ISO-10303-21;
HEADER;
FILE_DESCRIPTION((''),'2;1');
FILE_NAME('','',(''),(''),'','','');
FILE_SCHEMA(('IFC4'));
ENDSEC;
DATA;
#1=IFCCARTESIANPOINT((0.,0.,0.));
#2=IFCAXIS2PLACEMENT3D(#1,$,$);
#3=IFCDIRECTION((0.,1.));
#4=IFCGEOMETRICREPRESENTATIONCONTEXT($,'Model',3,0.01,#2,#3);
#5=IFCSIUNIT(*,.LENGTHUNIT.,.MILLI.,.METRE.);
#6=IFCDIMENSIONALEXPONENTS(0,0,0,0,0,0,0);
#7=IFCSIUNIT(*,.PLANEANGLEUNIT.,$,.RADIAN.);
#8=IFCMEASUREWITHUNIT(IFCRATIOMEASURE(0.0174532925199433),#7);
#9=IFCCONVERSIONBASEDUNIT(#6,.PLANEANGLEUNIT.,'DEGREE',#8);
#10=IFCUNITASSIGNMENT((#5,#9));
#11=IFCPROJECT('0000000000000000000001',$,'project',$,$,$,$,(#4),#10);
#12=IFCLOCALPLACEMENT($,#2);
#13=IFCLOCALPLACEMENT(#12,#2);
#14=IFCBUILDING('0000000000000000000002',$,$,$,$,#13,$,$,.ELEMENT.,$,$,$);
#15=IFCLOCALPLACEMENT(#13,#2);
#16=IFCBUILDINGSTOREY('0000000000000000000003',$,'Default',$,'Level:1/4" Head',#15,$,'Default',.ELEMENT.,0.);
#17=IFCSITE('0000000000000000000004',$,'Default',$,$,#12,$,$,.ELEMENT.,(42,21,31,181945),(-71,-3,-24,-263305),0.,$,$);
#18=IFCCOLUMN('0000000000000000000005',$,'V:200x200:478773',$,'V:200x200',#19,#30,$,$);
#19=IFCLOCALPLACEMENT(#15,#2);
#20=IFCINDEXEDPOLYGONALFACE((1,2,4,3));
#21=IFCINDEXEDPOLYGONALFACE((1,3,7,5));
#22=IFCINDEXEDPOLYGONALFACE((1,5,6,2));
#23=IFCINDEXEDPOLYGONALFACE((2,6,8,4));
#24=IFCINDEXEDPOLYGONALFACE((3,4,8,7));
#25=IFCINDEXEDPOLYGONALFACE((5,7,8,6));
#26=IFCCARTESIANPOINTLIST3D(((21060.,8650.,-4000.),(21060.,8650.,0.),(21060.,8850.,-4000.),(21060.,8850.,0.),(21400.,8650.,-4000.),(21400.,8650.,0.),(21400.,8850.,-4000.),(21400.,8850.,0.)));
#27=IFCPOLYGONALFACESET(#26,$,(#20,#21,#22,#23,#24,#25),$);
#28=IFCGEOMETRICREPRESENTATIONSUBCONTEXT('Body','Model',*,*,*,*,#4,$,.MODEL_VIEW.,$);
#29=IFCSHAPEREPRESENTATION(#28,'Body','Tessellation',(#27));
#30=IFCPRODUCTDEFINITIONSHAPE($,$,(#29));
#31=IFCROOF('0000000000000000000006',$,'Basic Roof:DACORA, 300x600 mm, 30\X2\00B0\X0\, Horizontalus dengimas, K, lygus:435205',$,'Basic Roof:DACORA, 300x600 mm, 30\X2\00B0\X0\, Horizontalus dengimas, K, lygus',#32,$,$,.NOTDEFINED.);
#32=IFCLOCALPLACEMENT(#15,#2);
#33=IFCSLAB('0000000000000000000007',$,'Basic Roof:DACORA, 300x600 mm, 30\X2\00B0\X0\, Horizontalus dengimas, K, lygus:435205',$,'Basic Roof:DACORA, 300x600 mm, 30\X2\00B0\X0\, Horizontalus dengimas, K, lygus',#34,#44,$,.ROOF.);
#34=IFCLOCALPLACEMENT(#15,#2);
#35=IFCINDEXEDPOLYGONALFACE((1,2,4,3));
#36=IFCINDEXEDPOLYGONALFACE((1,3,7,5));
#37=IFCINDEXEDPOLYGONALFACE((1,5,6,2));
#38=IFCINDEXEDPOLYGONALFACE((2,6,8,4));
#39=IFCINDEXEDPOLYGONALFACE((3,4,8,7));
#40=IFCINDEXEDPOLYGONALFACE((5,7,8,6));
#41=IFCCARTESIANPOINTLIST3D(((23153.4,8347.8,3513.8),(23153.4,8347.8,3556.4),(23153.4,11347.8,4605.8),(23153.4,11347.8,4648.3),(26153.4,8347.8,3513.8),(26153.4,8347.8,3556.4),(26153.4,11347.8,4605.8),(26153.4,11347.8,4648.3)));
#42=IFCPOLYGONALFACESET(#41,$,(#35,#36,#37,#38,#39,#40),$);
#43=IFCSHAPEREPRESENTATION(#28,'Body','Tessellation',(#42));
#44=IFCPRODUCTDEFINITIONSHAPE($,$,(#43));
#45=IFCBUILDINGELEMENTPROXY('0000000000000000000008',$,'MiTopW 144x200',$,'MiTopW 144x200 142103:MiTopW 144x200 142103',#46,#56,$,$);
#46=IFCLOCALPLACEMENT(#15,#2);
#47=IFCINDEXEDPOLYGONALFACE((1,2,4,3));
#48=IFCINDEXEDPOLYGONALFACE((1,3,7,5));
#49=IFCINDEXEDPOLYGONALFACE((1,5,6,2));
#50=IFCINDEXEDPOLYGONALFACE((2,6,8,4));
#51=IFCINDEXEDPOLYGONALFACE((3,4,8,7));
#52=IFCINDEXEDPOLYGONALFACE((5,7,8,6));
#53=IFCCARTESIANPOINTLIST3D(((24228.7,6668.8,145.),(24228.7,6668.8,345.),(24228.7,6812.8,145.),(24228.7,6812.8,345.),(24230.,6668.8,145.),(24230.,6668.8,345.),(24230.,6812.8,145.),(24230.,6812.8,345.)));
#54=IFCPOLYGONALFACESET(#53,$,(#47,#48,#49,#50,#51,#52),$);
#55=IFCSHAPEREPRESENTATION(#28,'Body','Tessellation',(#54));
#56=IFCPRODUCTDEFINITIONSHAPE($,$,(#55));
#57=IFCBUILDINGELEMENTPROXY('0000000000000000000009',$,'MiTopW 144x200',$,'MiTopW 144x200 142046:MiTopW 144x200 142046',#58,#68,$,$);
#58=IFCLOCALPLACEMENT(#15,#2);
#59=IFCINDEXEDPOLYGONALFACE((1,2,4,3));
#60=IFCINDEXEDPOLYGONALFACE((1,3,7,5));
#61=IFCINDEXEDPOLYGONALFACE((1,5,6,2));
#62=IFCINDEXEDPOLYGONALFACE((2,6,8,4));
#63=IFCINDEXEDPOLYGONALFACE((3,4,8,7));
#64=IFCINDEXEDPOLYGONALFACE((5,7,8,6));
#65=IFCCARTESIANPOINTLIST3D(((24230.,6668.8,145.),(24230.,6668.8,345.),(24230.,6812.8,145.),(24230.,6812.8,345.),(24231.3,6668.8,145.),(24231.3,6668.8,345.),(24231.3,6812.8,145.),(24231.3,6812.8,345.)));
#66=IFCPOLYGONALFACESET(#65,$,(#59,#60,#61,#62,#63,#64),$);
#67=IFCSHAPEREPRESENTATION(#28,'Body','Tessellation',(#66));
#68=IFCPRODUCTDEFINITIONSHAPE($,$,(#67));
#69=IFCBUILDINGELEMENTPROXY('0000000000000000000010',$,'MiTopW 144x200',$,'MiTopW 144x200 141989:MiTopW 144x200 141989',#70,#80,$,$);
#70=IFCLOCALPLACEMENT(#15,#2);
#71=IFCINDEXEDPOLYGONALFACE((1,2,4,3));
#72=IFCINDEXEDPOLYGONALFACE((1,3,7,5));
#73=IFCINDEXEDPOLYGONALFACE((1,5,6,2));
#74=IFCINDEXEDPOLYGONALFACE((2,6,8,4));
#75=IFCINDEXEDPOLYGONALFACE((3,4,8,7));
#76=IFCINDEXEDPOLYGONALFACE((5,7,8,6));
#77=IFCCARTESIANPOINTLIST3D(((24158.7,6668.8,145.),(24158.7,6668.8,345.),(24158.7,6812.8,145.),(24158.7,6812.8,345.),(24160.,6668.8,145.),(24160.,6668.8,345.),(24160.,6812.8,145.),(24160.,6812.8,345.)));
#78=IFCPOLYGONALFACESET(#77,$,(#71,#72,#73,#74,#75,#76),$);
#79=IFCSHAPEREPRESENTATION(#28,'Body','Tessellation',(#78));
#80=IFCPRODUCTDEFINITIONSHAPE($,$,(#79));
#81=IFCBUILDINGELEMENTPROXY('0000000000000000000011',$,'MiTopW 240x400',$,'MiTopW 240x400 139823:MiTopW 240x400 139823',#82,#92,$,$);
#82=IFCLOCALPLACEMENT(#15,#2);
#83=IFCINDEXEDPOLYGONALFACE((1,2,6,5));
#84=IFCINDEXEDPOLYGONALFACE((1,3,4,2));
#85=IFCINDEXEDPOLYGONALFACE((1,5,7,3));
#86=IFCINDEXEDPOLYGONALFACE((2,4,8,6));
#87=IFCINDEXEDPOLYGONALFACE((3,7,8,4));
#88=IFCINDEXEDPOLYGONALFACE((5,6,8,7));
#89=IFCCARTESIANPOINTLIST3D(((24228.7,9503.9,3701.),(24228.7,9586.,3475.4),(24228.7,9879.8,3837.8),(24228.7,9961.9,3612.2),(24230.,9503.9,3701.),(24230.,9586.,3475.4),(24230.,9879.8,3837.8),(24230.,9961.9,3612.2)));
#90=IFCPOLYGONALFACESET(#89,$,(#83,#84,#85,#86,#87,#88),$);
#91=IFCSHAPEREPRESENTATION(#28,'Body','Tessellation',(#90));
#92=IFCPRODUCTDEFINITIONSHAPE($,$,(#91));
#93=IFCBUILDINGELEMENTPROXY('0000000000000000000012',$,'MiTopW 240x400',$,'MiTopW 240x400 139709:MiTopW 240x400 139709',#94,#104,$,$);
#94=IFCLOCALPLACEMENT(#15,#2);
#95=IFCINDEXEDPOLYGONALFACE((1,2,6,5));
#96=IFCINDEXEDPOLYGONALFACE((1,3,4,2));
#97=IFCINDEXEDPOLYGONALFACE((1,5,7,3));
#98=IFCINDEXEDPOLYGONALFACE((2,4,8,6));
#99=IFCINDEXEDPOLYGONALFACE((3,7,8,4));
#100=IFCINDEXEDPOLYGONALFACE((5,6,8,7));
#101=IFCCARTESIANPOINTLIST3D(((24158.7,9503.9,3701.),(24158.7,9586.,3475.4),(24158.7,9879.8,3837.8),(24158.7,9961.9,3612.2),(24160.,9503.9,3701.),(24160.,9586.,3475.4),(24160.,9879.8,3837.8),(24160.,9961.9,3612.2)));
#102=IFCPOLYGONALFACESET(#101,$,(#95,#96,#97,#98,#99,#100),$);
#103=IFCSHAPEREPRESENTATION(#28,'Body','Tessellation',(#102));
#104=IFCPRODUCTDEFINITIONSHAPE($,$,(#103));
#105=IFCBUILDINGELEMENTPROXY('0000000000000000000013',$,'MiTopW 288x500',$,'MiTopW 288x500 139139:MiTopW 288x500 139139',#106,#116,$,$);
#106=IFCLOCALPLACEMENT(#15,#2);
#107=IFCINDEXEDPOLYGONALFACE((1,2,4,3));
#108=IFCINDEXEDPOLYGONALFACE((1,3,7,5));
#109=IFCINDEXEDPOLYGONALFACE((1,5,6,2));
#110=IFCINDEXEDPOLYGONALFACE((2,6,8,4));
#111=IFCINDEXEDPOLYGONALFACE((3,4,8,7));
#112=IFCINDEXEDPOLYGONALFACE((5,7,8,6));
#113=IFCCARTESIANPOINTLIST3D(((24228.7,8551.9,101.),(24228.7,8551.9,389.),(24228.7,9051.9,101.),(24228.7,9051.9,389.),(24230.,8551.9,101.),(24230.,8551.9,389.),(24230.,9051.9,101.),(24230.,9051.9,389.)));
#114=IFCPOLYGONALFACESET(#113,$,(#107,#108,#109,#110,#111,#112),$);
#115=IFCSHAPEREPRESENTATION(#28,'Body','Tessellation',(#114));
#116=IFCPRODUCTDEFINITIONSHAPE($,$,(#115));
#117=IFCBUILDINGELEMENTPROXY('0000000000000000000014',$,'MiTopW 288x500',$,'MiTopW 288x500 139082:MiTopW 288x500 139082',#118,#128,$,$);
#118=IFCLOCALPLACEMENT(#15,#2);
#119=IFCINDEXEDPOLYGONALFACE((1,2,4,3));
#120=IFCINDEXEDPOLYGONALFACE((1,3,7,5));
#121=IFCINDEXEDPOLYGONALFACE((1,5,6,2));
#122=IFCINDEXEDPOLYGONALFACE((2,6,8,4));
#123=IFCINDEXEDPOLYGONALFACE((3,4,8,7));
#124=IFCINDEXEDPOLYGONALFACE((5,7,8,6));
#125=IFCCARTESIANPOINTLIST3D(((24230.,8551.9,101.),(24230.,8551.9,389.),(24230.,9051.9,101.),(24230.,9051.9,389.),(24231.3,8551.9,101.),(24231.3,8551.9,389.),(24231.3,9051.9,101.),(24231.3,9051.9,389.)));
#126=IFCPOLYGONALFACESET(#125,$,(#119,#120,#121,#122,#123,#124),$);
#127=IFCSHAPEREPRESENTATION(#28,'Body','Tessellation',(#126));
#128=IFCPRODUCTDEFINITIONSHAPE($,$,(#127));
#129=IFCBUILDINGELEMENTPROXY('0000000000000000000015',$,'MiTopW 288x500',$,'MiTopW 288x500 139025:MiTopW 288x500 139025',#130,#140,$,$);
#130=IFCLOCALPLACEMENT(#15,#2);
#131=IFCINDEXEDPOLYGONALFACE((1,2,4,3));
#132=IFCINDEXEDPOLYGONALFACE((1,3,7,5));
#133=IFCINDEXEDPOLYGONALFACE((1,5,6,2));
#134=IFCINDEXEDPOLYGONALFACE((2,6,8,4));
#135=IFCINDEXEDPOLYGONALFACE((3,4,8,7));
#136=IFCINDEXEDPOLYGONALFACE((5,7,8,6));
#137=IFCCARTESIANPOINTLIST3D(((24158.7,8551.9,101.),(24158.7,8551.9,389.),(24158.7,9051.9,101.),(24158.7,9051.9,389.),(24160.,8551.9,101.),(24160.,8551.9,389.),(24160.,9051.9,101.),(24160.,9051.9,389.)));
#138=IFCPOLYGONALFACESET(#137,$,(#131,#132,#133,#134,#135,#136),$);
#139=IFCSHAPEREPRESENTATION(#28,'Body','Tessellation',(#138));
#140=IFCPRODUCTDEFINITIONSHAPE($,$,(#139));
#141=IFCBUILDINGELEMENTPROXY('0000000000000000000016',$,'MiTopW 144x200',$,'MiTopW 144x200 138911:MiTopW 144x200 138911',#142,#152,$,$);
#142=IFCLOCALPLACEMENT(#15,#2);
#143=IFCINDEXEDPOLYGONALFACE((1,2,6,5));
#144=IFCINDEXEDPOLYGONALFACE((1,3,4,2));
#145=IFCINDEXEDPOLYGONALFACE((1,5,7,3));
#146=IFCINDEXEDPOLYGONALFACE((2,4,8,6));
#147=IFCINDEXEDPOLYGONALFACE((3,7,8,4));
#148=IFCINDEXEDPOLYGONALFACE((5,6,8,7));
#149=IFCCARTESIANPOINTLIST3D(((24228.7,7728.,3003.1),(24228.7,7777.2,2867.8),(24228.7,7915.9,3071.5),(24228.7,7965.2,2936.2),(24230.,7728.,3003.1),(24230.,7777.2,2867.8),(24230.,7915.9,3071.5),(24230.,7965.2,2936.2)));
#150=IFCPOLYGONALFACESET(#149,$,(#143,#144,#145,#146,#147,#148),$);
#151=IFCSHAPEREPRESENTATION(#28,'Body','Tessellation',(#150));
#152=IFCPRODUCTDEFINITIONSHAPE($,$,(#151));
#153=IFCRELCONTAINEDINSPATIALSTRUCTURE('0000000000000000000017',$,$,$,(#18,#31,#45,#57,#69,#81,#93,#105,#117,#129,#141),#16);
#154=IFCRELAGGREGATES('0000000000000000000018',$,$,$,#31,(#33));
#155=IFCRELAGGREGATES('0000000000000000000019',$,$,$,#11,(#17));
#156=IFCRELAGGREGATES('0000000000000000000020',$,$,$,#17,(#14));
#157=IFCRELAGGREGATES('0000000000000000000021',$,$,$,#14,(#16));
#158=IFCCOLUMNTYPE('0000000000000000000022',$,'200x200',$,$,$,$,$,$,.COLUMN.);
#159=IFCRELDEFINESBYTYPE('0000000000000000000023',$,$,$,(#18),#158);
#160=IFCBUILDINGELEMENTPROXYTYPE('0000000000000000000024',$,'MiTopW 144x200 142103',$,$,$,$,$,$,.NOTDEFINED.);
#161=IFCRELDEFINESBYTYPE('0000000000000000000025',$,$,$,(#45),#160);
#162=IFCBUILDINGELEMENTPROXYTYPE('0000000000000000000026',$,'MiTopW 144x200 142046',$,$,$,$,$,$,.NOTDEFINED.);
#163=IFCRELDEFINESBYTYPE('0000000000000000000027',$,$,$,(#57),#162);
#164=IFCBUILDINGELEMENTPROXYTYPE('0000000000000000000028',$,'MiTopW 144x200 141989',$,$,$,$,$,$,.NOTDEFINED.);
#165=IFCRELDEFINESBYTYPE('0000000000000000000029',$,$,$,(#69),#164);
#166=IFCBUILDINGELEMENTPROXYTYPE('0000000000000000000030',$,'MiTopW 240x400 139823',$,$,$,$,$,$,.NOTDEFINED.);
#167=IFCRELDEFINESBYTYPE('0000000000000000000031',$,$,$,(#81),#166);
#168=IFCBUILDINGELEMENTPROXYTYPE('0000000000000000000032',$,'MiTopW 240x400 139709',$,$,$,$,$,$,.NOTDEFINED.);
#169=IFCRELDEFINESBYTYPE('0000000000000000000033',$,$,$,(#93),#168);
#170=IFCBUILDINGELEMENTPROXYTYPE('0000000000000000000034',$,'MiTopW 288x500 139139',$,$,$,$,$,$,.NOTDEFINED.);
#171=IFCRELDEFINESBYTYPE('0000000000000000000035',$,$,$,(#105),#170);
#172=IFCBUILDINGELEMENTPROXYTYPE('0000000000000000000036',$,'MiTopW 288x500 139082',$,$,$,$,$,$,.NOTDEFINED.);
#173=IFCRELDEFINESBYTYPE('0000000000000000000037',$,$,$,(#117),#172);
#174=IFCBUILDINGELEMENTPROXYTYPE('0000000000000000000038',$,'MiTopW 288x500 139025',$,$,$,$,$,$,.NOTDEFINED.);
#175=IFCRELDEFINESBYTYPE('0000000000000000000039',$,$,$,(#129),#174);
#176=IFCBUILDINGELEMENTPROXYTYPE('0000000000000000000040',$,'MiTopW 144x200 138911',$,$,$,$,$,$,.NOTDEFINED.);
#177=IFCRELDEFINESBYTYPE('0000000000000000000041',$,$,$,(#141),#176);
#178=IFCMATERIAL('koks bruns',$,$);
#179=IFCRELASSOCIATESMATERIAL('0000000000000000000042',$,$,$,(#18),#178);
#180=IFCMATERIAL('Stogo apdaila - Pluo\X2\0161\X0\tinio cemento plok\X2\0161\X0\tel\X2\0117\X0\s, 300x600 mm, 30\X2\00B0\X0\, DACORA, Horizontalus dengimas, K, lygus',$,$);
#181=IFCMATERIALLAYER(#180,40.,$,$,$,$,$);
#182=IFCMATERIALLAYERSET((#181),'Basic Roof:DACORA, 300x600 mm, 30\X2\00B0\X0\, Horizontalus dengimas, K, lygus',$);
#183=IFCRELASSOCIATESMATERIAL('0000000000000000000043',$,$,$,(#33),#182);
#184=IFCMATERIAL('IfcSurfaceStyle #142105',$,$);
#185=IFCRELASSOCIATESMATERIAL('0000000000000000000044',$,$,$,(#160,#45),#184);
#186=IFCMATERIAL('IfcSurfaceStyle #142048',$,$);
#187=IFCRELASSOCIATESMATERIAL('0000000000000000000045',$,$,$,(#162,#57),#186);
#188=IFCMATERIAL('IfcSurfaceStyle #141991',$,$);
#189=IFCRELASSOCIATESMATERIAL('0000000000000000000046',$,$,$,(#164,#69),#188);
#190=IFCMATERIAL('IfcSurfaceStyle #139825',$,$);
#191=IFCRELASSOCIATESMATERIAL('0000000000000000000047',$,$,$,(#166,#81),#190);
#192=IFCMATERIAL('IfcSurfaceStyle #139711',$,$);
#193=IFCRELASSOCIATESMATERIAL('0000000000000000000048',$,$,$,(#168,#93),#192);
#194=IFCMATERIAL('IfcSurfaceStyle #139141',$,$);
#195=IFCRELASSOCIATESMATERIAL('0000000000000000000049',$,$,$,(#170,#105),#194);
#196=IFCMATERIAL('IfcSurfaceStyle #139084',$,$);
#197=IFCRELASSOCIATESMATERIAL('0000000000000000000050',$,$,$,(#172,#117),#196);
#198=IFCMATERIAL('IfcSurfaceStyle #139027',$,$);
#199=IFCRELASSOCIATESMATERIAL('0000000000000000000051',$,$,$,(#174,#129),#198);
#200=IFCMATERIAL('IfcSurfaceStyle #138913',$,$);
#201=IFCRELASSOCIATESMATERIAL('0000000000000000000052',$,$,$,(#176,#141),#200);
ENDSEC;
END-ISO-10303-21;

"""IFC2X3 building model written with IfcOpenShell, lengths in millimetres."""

from ifc_helpers import new_model, entity, si_unit, converted_unit, direction, frame, frame_2d, origin, origin_2d_with_axis, place, context, subcontext, project, spatial, polyline, rectangle, outline, extrude, source, transform, mapped, material, layer, layer_set, type_object, type_shapes, element, aggregate, save


model = new_model("IFC2X3")

# Units and contexts
model_context = context("Model", 3, precision=0.01, world=origin(), true_north=direction((0.0, 1.0)))
body_context = subcontext(model_context, "Body", "Model", "MODEL_VIEW")
ifc_project = project(units=[si_unit("LENGTHUNIT", "METRE", prefix="MILLI"), converted_unit("PLANEANGLEUNIT", "DEGREE", entity("IfcRatioMeasure", 0.0174532925199433), si_unit("PLANEANGLEUNIT", "RADIAN"), dimensions=[0, 0, 0, 0, 0, 0, 0])], contexts=[model_context])

# Site, building, storey
site_placement = place(None, origin())
site = spatial("IfcSite", under=ifc_project, at=site_placement, Name="Default", CompositionType="ELEMENT", RefLatitude=(42, 21, 31, 181945), RefLongitude=(-71, -3, -24, -263305), RefElevation=0.0)
building_placement = place(site_placement, origin())
building = spatial("IfcBuilding", under=site, at=building_placement, CompositionType="ELEMENT")
storey_placement = place(building_placement, origin())
storey = spatial("IfcBuildingStorey", under=building, at=storey_placement, Name="Default", ObjectType="Level:1/4\" Head", LongName="Default", CompositionType="ELEMENT", Elevation=0.0)

# Column
ifc_material_1 = material(Name="koks bruns")
column_type = type_object("IfcColumnType", Name="200x200", PredefinedType="COLUMN")
shared_shape_1 = source(origin(), body_context, "Body", "SweptSolid", [
    extrude(rectangle(XDim=340.0, YDim=200.0, at=origin_2d_with_axis()), frame((100.0, 280.0, -4000.0), z_axis=(0.0, 0.0, 1.0), x_axis=(0.0, -1.0, 0.0)), (0.0, 0.0, 1.0), 4000.0),
])
type_shapes(column_type, [shared_shape_1])
column_placement = place(storey_placement, frame((21510.0, 8650.0, 0.0), z_axis=(0.0, 0.0, 1.0), x_axis=(0.0, 1.0, 0.0)))
element("IfcColumn", 1, at=column_placement, inside=storey, type_object=column_type, material=ifc_material_1, Name="V:200x200:478773", ObjectType="V:200x200", context=body_context, shape_type="MappedRepresentation", body=[
    mapped(shared_shape_1, transform((0.0, 0.0, 0.0), scale=1.0)),
])

# Roof, slab
roof_placement = place(storey_placement, frame((23153.4, 8347.8, 3513.8)))
roof = element("IfcRoof", 2, at=roof_placement, inside=storey, Name="Basic Roof:DACORA, 300x600 mm, 30°, Horizontalus dengimas, K, lygus:435205", ObjectType="Basic Roof:DACORA, 300x600 mm, 30°, Horizontalus dengimas, K, lygus", ShapeType="NOTDEFINED")
ifc_material_2 = material(Name="Stogo apdaila - Pluoštinio cemento plokštelės, 300x600 mm, 30°, DACORA, Horizontalus dengimas, K, lygus")
ifc_layer = layer(ifc_material_2, 40.0)
ifc_layer_set = layer_set([ifc_layer], Name="Basic Roof:DACORA, 300x600 mm, 30°, Horizontalus dengimas, K, lygus")
slab_placement = place(roof_placement, origin())
slab = element("IfcSlab", 3, at=slab_placement, material=ifc_layer_set, Name="Basic Roof:DACORA, 300x600 mm, 30°, Horizontalus dengimas, K, lygus:435205", ObjectType="Basic Roof:DACORA, 300x600 mm, 30°, Horizontalus dengimas, K, lygus", PredefinedType="ROOF", context=body_context, shape_type="SweptSolid", body=[
    extrude(rectangle(XDim=3192.5, YDim=3000.0, at=frame_2d((0.0, 0.0), x_axis=(0.0, -1.0))), frame((1500.0, 1500.0, 546.0), z_axis=(0.0, -0.34202, 0.939693), x_axis=(1.0, 0.0, 0.0)), (0.0, 0.34202, 0.939693), 42.6),
])
aggregate(roof, [slab])

# Building element proxies
ifc_material_3 = material(Name="IfcSurfaceStyle #142105")
building_element_proxy_type_1 = type_object("IfcBuildingElementProxyType", Name="MiTopW 144x200 142103", PredefinedType="NOTDEFINED", material=ifc_material_3)
shared_shape_2 = source(origin(), body_context, "Body", "SweptSolid", [
    extrude(rectangle(XDim=200.0, YDim=144.0, at=frame_2d((0.0, 0.0), x_axis=(1.0, 0.0))), frame((100.0, 72.0, 0.0), z_axis=(0.0, 0.0, 1.0), x_axis=(-1.0, 0.0, 0.0)), (0.0, 0.0, 1.0), 1.3),
])
type_shapes(building_element_proxy_type_1, [shared_shape_2])
proxy_1_placement = place(building_placement, frame((24230.0, 6668.8, 145.0), z_axis=(-1.0, 0.0, 0.0), x_axis=(0.0, 0.0, 1.0)))
element("IfcBuildingElementProxy", 4, at=proxy_1_placement, inside=storey, type_object=building_element_proxy_type_1, material=ifc_material_3, Name="MiTopW 144x200", ObjectType="MiTopW 144x200 142103:MiTopW 144x200 142103", context=body_context, shape_type="MappedRepresentation", body=[
    mapped(shared_shape_2, transform((0.0, 0.0, 0.0), scale=1.0)),
])
ifc_material_4 = material(Name="IfcSurfaceStyle #142048")
building_element_proxy_type_2 = type_object("IfcBuildingElementProxyType", Name="MiTopW 144x200 142046", PredefinedType="NOTDEFINED", material=ifc_material_4)
shared_shape_3 = source(origin(), body_context, "Body", "SweptSolid", [
    extrude(rectangle(XDim=200.0, YDim=144.0, at=frame_2d((0.0, 0.0), x_axis=(1.0, 0.0))), frame((100.0, 72.0, 0.0), z_axis=(0.0, 0.0, 1.0), x_axis=(-1.0, 0.0, 0.0)), (0.0, 0.0, 1.0), 1.3),
])
type_shapes(building_element_proxy_type_2, [shared_shape_3])
proxy_2_placement = place(building_placement, frame((24231.3, 6668.8, 145.0), z_axis=(-1.0, 0.0, 0.0), x_axis=(0.0, 0.0, 1.0)))
element("IfcBuildingElementProxy", 5, at=proxy_2_placement, inside=storey, type_object=building_element_proxy_type_2, material=ifc_material_4, Name="MiTopW 144x200", ObjectType="MiTopW 144x200 142046:MiTopW 144x200 142046", context=body_context, shape_type="MappedRepresentation", body=[
    mapped(shared_shape_3, transform((0.0, 0.0, 0.0), scale=1.0)),
])
ifc_material_5 = material(Name="IfcSurfaceStyle #141991")
building_element_proxy_type_3 = type_object("IfcBuildingElementProxyType", Name="MiTopW 144x200 141989", PredefinedType="NOTDEFINED", material=ifc_material_5)
shared_shape_4 = source(origin(), body_context, "Body", "SweptSolid", [
    extrude(rectangle(XDim=200.0, YDim=144.0, at=frame_2d((0.0, 0.0), x_axis=(1.0, 0.0))), frame((100.0, 72.0, 0.0), z_axis=(0.0, 0.0, 1.0), x_axis=(-1.0, 0.0, 0.0)), (0.0, 0.0, 1.0), 1.3),
])
type_shapes(building_element_proxy_type_3, [shared_shape_4])
proxy_3_placement = place(building_placement, frame((24160.0, 6668.8, 145.0), z_axis=(-1.0, 0.0, 0.0), x_axis=(0.0, 0.0, 1.0)))
element("IfcBuildingElementProxy", 6, at=proxy_3_placement, inside=storey, type_object=building_element_proxy_type_3, material=ifc_material_5, Name="MiTopW 144x200", ObjectType="MiTopW 144x200 141989:MiTopW 144x200 141989", context=body_context, shape_type="MappedRepresentation", body=[
    mapped(shared_shape_4, transform((0.0, 0.0, 0.0), scale=1.0)),
])
ifc_material_6 = material(Name="IfcSurfaceStyle #139825")
building_element_proxy_type_4 = type_object("IfcBuildingElementProxyType", Name="MiTopW 240x400 139823", PredefinedType="NOTDEFINED", material=ifc_material_6)
shared_shape_5 = source(origin(), body_context, "Body", "SweptSolid", [
    extrude(outline(polyline([(-200.0, -120.0), (200.0, -120.0), (200.0, 120.0), (-200.0, 120.0), (-200.0, -120.0)])), frame((200.0, 120.0, 0.0), z_axis=(0.0, 0.0, 1.0), x_axis=(-1.0, 0.0, 0.0)), (0.0, 0.0, 1.0), 1.3),
])
type_shapes(building_element_proxy_type_4, [shared_shape_5])
proxy_4_placement = place(building_placement, frame((24230.0, 9961.9, 3612.2), z_axis=(-1.0, 0.0, 0.0), x_axis=(0.0, -0.939693, -0.34202)))
element("IfcBuildingElementProxy", 7, at=proxy_4_placement, inside=storey, type_object=building_element_proxy_type_4, material=ifc_material_6, Name="MiTopW 240x400", ObjectType="MiTopW 240x400 139823:MiTopW 240x400 139823", context=body_context, shape_type="MappedRepresentation", body=[
    mapped(shared_shape_5, transform((0.0, 0.0, 0.0), scale=1.0)),
])
ifc_material_7 = material(Name="IfcSurfaceStyle #139711")
building_element_proxy_type_5 = type_object("IfcBuildingElementProxyType", Name="MiTopW 240x400 139709", PredefinedType="NOTDEFINED", material=ifc_material_7)
shared_shape_6 = source(origin(), body_context, "Body", "SweptSolid", [
    extrude(outline(polyline([(-200.0, -120.0), (200.0, -120.0), (200.0, 120.0), (-200.0, 120.0), (-200.0, -120.0)])), frame((200.0, 120.0, 0.0), z_axis=(0.0, 0.0, 1.0), x_axis=(-1.0, 0.0, 0.0)), (0.0, 0.0, 1.0), 1.3),
])
type_shapes(building_element_proxy_type_5, [shared_shape_6])
proxy_5_placement = place(building_placement, frame((24160.0, 9961.9, 3612.2), z_axis=(-1.0, 0.0, 0.0), x_axis=(0.0, -0.939693, -0.34202)))
element("IfcBuildingElementProxy", 8, at=proxy_5_placement, inside=storey, type_object=building_element_proxy_type_5, material=ifc_material_7, Name="MiTopW 240x400", ObjectType="MiTopW 240x400 139709:MiTopW 240x400 139709", context=body_context, shape_type="MappedRepresentation", body=[
    mapped(shared_shape_6, transform((0.0, 0.0, 0.0), scale=1.0)),
])
ifc_material_8 = material(Name="IfcSurfaceStyle #139141")
building_element_proxy_type_6 = type_object("IfcBuildingElementProxyType", Name="MiTopW 288x500 139139", PredefinedType="NOTDEFINED", material=ifc_material_8)
shared_shape_7 = source(origin(), body_context, "Body", "SweptSolid", [
    extrude(rectangle(XDim=500.0, YDim=288.0, at=frame_2d((0.0, 0.0), x_axis=(1.0, 0.0))), frame((250.0, 144.0, 0.0), z_axis=(0.0, 0.0, 1.0), x_axis=(-1.0, 0.0, 0.0)), (0.0, 0.0, 1.0), 1.3),
])
type_shapes(building_element_proxy_type_6, [shared_shape_7])
proxy_6_placement = place(building_placement, frame((24230.0, 8551.9, 389.0), z_axis=(-1.0, 0.0, 0.0), x_axis=(0.0, 1.0, 0.0)))
element("IfcBuildingElementProxy", 9, at=proxy_6_placement, inside=storey, type_object=building_element_proxy_type_6, material=ifc_material_8, Name="MiTopW 288x500", ObjectType="MiTopW 288x500 139139:MiTopW 288x500 139139", context=body_context, shape_type="MappedRepresentation", body=[
    mapped(shared_shape_7, transform((0.0, 0.0, 0.0), scale=1.0)),
])
ifc_material_9 = material(Name="IfcSurfaceStyle #139084")
building_element_proxy_type_7 = type_object("IfcBuildingElementProxyType", Name="MiTopW 288x500 139082", PredefinedType="NOTDEFINED", material=ifc_material_9)
shared_shape_8 = source(origin(), body_context, "Body", "SweptSolid", [
    extrude(rectangle(XDim=500.0, YDim=288.0, at=frame_2d((0.0, 0.0), x_axis=(1.0, 0.0))), frame((250.0, 144.0, 0.0), z_axis=(0.0, 0.0, 1.0), x_axis=(-1.0, 0.0, 0.0)), (0.0, 0.0, 1.0), 1.3),
])
type_shapes(building_element_proxy_type_7, [shared_shape_8])
proxy_7_placement = place(building_placement, frame((24231.3, 8551.9, 389.0), z_axis=(-1.0, 0.0, 0.0), x_axis=(0.0, 1.0, 0.0)))
element("IfcBuildingElementProxy", 10, at=proxy_7_placement, inside=storey, type_object=building_element_proxy_type_7, material=ifc_material_9, Name="MiTopW 288x500", ObjectType="MiTopW 288x500 139082:MiTopW 288x500 139082", context=body_context, shape_type="MappedRepresentation", body=[
    mapped(shared_shape_8, transform((0.0, 0.0, 0.0), scale=1.0)),
])
ifc_material_10 = material(Name="IfcSurfaceStyle #139027")
building_element_proxy_type_8 = type_object("IfcBuildingElementProxyType", Name="MiTopW 288x500 139025", PredefinedType="NOTDEFINED", material=ifc_material_10)
shared_shape_9 = source(origin(), body_context, "Body", "SweptSolid", [
    extrude(rectangle(XDim=500.0, YDim=288.0, at=frame_2d((0.0, 0.0), x_axis=(1.0, 0.0))), frame((250.0, 144.0, 0.0), z_axis=(0.0, 0.0, 1.0), x_axis=(-1.0, 0.0, 0.0)), (0.0, 0.0, 1.0), 1.3),
])
type_shapes(building_element_proxy_type_8, [shared_shape_9])
proxy_8_placement = place(building_placement, frame((24160.0, 8551.9, 389.0), z_axis=(-1.0, 0.0, 0.0), x_axis=(0.0, 1.0, 0.0)))
element("IfcBuildingElementProxy", 11, at=proxy_8_placement, inside=storey, type_object=building_element_proxy_type_8, material=ifc_material_10, Name="MiTopW 288x500", ObjectType="MiTopW 288x500 139025:MiTopW 288x500 139025", context=body_context, shape_type="MappedRepresentation", body=[
    mapped(shared_shape_9, transform((0.0, 0.0, 0.0), scale=1.0)),
])
ifc_material_11 = material(Name="IfcSurfaceStyle #138913")
building_element_proxy_type_9 = type_object("IfcBuildingElementProxyType", Name="MiTopW 144x200 138911", PredefinedType="NOTDEFINED", material=ifc_material_11)
shared_shape_10 = source(origin(), body_context, "Body", "SweptSolid", [
    extrude(outline(polyline([(-100.0, -72.0), (100.0, -72.0), (100.0, 72.0), (-100.0, 72.0), (-100.0, -72.0)])), frame((100.0, 72.0, 0.0), z_axis=(0.0, 0.0, 1.0), x_axis=(-1.0, 0.0, 0.0)), (0.0, 0.0, 1.0), 1.3),
])
type_shapes(building_element_proxy_type_9, [shared_shape_10])
proxy_9_placement = place(building_placement, frame((24230.0, 7965.2, 2936.2), z_axis=(-1.0, 0.0, 0.0), x_axis=(0.0, -0.939693, -0.34202)))
element("IfcBuildingElementProxy", 12, at=proxy_9_placement, inside=storey, type_object=building_element_proxy_type_9, material=ifc_material_11, Name="MiTopW 144x200", ObjectType="MiTopW 144x200 138911:MiTopW 144x200 138911", context=body_context, shape_type="MappedRepresentation", body=[
    mapped(shared_shape_10, transform((0.0, 0.0, 0.0), scale=1.0)),
])

save(model, "model.ifc")
